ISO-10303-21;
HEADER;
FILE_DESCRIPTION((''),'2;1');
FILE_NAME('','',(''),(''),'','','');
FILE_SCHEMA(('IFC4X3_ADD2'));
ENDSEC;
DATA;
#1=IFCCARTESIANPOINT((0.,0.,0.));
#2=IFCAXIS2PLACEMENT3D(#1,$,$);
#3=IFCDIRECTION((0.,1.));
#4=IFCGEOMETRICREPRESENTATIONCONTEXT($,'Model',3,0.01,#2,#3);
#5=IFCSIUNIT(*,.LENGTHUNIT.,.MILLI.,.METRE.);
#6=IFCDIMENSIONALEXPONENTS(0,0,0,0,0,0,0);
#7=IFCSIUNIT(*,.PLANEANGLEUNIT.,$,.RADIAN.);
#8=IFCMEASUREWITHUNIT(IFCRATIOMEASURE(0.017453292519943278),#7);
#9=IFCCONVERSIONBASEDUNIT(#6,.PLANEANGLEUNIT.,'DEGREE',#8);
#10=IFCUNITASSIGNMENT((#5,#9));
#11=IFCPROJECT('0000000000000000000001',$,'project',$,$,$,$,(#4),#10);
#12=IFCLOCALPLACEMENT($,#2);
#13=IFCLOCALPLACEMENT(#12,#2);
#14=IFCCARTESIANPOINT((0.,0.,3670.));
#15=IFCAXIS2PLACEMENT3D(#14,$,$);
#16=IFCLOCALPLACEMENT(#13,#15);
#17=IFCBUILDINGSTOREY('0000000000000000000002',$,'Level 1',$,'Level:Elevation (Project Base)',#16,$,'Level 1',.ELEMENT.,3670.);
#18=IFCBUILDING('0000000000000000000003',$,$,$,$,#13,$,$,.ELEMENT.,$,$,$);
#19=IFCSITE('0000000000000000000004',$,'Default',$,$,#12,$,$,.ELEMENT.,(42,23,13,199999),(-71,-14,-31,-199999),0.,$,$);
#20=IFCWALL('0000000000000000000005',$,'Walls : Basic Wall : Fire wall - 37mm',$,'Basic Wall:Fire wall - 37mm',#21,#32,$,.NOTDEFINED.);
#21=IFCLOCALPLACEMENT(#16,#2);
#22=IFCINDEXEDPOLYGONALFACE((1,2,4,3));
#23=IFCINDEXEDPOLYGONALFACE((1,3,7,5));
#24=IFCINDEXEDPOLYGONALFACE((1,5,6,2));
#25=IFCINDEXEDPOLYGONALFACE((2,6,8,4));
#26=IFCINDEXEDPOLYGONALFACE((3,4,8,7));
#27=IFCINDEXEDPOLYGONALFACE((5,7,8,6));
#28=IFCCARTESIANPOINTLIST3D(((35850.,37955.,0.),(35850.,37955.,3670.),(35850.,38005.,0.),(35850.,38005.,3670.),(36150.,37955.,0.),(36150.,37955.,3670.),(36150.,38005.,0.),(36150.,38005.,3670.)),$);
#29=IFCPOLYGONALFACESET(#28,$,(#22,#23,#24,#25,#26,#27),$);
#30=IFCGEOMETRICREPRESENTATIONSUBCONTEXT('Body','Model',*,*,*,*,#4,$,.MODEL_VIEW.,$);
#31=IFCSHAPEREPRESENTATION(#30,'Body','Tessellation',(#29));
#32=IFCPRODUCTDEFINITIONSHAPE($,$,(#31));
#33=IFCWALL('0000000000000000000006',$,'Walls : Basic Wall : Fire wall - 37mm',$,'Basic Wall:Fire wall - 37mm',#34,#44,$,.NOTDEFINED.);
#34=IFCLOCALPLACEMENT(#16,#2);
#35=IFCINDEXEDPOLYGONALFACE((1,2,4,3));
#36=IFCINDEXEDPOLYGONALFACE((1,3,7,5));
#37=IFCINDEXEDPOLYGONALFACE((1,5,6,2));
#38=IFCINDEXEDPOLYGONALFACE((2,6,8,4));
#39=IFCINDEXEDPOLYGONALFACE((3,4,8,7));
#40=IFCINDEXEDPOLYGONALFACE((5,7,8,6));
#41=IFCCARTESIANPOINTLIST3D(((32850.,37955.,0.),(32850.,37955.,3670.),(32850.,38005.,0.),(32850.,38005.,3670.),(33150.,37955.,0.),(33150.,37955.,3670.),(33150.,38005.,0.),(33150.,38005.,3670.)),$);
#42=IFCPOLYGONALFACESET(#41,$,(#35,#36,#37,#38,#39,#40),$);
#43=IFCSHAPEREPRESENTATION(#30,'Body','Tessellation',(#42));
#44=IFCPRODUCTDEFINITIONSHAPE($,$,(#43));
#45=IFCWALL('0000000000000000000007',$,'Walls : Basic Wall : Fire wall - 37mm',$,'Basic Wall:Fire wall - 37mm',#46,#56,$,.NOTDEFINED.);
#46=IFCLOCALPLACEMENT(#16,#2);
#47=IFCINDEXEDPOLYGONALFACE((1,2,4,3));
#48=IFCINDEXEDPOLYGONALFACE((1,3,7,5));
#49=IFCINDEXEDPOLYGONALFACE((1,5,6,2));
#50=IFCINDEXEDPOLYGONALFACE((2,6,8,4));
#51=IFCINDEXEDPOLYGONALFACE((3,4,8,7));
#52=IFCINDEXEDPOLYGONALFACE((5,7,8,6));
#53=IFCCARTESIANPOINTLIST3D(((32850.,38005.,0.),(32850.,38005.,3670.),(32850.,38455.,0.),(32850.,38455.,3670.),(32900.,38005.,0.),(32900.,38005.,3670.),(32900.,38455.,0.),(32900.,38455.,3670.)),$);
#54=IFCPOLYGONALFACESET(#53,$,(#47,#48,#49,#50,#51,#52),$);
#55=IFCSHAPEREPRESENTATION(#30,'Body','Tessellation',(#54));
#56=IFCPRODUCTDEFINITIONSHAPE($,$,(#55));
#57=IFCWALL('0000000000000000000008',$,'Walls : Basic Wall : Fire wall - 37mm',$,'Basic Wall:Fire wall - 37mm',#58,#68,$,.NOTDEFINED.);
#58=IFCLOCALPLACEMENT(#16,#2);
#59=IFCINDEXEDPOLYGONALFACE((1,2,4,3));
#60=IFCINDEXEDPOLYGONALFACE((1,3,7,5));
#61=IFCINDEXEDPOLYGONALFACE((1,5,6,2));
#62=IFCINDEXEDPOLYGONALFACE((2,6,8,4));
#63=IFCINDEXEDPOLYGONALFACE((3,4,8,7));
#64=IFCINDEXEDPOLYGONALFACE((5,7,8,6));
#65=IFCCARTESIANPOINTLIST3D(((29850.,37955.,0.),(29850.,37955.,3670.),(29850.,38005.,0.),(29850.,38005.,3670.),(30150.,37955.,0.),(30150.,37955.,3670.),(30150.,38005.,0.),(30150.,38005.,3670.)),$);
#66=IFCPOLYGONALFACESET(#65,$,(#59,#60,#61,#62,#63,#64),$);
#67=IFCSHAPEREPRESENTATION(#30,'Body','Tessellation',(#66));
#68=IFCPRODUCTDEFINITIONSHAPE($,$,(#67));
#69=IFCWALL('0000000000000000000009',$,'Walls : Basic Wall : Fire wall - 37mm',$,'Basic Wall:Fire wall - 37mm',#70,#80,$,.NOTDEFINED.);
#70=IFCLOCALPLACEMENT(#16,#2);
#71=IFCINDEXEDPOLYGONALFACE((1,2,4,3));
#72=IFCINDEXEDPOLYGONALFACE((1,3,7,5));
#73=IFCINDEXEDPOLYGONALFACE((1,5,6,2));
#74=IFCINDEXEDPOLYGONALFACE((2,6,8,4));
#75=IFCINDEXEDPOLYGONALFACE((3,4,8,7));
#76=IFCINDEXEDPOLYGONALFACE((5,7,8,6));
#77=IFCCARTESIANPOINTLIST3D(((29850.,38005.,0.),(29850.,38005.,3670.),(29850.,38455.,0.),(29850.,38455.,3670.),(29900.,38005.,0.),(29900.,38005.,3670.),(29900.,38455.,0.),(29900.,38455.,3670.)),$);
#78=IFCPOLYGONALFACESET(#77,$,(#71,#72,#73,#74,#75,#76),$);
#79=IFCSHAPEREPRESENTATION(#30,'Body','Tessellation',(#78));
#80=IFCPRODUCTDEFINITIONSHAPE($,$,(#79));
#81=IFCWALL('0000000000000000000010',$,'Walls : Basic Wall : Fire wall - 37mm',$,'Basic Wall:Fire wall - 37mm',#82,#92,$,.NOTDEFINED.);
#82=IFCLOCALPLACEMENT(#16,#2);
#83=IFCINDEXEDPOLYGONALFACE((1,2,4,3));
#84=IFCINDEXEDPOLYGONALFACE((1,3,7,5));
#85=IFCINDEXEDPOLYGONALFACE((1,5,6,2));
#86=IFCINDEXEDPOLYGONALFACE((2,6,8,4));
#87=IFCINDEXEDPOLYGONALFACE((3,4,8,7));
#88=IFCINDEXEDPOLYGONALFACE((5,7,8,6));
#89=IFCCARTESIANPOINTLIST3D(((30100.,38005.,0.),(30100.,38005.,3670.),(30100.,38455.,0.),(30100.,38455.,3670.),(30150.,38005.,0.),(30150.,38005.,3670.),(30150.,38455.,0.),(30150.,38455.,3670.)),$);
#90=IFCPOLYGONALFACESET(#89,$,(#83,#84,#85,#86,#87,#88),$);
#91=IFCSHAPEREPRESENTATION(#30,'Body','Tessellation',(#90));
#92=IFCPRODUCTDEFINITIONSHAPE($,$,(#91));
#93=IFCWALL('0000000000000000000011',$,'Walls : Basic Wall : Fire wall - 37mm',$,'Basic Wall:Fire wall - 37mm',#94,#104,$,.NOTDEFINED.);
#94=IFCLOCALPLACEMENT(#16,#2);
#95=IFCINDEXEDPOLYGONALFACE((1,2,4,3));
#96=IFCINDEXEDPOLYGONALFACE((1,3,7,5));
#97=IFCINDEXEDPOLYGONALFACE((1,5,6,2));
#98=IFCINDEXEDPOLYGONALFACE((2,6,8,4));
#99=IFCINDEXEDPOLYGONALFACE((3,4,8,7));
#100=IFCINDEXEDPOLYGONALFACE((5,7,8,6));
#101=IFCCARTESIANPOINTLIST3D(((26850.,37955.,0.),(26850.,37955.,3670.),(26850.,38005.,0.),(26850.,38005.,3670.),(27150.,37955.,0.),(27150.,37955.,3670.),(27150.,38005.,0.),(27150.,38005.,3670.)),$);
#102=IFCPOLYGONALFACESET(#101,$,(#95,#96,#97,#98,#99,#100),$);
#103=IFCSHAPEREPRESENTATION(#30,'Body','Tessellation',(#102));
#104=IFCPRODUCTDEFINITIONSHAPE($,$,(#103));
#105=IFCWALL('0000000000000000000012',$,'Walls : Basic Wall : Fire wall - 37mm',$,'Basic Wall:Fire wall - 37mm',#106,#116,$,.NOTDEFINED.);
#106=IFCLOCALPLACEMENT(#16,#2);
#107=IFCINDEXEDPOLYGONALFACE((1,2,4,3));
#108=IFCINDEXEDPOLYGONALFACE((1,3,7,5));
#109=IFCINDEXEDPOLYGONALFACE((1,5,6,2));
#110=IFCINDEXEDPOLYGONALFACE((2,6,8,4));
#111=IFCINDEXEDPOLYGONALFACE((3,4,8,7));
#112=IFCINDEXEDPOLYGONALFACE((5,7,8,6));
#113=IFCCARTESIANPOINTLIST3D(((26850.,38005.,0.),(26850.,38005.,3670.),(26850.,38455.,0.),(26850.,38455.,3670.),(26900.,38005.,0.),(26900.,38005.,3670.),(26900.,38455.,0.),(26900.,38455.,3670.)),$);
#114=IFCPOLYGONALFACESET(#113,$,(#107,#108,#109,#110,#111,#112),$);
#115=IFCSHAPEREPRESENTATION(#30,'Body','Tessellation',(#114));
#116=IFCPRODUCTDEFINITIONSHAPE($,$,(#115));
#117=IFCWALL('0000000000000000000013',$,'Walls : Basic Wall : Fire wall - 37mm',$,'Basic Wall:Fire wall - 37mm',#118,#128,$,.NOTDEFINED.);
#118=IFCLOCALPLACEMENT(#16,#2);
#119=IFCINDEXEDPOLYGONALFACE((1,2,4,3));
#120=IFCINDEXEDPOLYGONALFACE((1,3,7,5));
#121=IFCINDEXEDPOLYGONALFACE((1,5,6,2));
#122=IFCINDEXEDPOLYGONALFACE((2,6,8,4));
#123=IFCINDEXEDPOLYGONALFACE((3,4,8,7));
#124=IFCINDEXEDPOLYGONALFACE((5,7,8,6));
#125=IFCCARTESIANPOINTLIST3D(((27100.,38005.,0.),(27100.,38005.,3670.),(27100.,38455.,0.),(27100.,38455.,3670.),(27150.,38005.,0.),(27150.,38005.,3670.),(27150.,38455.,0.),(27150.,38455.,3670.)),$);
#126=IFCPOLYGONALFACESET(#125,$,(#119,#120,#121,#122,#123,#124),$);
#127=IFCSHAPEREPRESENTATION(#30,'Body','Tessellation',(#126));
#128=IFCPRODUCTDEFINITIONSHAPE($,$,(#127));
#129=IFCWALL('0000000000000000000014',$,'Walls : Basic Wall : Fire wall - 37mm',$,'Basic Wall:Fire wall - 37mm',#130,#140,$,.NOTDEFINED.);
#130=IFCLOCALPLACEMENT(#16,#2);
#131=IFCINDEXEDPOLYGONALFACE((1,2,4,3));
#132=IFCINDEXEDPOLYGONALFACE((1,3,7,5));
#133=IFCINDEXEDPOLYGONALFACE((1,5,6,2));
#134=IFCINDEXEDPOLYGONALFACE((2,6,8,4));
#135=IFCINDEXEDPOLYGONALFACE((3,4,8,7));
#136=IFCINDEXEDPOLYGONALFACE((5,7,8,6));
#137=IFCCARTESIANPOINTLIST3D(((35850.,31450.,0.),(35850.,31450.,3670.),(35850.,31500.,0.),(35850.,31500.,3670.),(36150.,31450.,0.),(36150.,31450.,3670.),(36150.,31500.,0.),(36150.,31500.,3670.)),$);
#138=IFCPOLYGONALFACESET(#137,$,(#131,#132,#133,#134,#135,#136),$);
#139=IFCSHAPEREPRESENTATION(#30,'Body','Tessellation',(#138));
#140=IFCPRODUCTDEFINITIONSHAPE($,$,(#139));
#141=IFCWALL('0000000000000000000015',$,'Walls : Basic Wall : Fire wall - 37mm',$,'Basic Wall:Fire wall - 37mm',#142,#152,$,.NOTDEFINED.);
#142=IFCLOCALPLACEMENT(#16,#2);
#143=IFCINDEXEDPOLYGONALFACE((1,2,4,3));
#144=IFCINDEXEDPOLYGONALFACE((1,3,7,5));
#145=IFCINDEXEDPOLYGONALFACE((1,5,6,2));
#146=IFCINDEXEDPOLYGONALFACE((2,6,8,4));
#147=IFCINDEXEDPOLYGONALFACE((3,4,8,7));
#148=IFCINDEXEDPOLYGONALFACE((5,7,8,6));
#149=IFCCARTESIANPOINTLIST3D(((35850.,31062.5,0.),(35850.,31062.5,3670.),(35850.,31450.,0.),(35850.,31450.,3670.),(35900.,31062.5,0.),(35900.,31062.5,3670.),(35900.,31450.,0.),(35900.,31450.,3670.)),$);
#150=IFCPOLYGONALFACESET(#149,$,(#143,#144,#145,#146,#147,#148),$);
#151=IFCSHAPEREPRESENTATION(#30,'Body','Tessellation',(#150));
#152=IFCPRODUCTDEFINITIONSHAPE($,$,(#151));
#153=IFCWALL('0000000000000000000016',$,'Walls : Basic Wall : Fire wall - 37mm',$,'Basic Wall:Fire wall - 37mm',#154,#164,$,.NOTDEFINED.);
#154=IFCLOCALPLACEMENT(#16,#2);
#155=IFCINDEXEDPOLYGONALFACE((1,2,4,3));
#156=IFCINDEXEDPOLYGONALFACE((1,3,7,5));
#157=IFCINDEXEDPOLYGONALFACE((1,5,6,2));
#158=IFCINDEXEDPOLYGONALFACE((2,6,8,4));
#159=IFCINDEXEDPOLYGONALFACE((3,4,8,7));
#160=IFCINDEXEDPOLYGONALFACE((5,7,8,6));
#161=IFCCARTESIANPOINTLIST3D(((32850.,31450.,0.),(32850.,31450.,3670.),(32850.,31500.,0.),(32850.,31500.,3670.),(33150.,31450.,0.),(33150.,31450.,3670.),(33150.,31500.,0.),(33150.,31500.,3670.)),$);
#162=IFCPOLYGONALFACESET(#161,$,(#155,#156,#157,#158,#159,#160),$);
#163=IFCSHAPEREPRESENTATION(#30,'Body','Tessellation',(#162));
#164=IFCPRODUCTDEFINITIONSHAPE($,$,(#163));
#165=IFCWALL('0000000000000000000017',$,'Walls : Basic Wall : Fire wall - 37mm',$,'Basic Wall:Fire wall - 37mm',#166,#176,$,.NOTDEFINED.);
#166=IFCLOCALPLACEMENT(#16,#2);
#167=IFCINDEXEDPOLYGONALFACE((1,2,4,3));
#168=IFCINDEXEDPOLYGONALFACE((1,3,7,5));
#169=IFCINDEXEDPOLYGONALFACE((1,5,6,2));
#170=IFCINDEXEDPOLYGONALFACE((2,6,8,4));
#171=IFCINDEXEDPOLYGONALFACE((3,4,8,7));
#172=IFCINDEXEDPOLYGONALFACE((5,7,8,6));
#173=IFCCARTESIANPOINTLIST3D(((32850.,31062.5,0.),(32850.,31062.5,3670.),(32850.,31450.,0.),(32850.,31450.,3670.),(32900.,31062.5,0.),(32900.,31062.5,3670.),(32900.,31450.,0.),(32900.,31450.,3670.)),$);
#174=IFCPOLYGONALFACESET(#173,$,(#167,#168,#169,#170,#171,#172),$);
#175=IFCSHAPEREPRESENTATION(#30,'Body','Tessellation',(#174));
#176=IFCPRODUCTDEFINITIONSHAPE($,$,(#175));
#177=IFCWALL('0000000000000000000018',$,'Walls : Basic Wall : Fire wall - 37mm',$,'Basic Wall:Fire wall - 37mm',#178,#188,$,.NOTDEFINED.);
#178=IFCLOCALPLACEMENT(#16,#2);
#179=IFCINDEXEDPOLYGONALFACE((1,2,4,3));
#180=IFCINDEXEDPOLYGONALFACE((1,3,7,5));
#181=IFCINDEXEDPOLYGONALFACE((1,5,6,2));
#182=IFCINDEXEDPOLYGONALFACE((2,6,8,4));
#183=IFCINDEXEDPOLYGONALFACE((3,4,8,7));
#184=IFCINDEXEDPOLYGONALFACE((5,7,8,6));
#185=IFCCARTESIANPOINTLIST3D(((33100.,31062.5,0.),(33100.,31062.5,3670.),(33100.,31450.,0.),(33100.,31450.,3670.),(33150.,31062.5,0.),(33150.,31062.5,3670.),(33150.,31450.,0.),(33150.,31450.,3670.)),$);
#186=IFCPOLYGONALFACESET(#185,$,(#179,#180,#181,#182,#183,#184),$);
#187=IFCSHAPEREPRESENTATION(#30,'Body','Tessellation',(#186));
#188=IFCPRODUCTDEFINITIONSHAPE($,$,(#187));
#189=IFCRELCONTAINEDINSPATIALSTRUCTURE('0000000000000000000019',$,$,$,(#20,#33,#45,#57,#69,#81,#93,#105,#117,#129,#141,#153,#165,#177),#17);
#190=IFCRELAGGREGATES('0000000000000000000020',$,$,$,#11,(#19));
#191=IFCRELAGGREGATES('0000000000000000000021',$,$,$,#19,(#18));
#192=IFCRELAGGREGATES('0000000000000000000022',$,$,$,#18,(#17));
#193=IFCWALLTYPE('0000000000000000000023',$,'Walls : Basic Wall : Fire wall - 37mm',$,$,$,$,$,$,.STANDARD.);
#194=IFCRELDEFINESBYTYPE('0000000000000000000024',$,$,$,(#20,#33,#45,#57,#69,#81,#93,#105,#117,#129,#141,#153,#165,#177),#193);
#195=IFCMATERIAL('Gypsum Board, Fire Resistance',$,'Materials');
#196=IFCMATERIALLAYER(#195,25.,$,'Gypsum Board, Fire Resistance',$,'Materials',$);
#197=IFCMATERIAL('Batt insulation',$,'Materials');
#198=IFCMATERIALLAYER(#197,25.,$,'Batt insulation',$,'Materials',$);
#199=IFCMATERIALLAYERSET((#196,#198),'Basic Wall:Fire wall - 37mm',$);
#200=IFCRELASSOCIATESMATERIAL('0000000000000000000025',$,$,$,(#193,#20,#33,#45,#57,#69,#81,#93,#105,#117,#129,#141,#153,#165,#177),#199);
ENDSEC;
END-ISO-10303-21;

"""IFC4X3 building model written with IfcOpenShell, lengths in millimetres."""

from ifc_helpers import new_model, entity, si_unit, converted_unit, direction, frame, frame_2d, origin, place, context, subcontext, project, spatial, rectangle, extrude, material, layer, layer_set, type_object, element, save


model = new_model("IFC4X3")

# Units and contexts
model_context = context("Model", 3, precision=0.01, world=origin(), true_north=direction((0.0, 1.0)))
body_context = subcontext(model_context, "Body", "Model", "MODEL_VIEW")
ifc_project = project(units=[si_unit("LENGTHUNIT", "METRE", prefix="MILLI"), converted_unit("PLANEANGLEUNIT", "DEGREE", entity("IfcRatioMeasure", 0.017453292519943278), si_unit("PLANEANGLEUNIT", "RADIAN"), dimensions=[0, 0, 0, 0, 0, 0, 0])], contexts=[model_context])

# Site, building, storey
site_placement = place(None, origin())
site = spatial("IfcSite", under=ifc_project, at=site_placement, Name="Default", CompositionType="ELEMENT", RefLatitude=(42, 23, 13, 199999), RefLongitude=(-71, -14, -31, -199999), RefElevation=0.0)
building_placement = place(site_placement, origin())
building = spatial("IfcBuilding", under=site, at=building_placement, CompositionType="ELEMENT")
storey_placement = place(building_placement, frame((0.0, 0.0, 3670.0)))
storey = spatial("IfcBuildingStorey", under=building, at=storey_placement, Name="Level 1", ObjectType="Level:Elevation (Project Base)", LongName="Level 1", CompositionType="ELEMENT", Elevation=3670.0)

# Walls
ifc_material_1 = material(Name="Gypsum Board, Fire Resistance", Category="Materials")
ifc_layer_1 = layer(ifc_material_1, 25.0, Name="Gypsum Board, Fire Resistance", Category="Materials")
ifc_material_2 = material(Name="Batt insulation", Category="Materials")
ifc_layer_2 = layer(ifc_material_2, 25.0, Name="Batt insulation", Category="Materials")
ifc_layer_set = layer_set([ifc_layer_1, ifc_layer_2], Name="Basic Wall:Fire wall - 37mm")
wall_type = type_object("IfcWallType", Name="Walls : Basic Wall : Fire wall - 37mm", PredefinedType="STANDARD", material=ifc_layer_set)
for number, where, name in (
    (1, (35850.0, 37980.0, 0.0), "Walls : Basic Wall : Fire wall - 37mm"),
    (2, (32850.0, 37980.0, 0.0), "Walls : Basic Wall : Fire wall - 37mm"),
):
    element("IfcWall", number, at=place(storey_placement, frame(where)), inside=storey, type_object=wall_type, material=ifc_layer_set, Name=name, ObjectType="Basic Wall:Fire wall - 37mm", PredefinedType="NOTDEFINED", context=body_context, shape_type="SweptSolid", body=[
        extrude(rectangle(XDim=300.0, YDim=50.0, at=frame_2d((150.0, 0.0), x_axis=(-1.0, 0.0))), origin(), (0.0, 0.0, 1.0), 3670.0),
    ])
wall_1_placement = place(storey_placement, frame((32875.0, 38455.0, 0.0), z_axis=(0.0, 0.0, 1.0), x_axis=(0.0, -1.0, 0.0)))
element("IfcWall", 3, at=wall_1_placement, inside=storey, type_object=wall_type, material=ifc_layer_set, Name="Walls : Basic Wall : Fire wall - 37mm", ObjectType="Basic Wall:Fire wall - 37mm", PredefinedType="NOTDEFINED", context=body_context, shape_type="SweptSolid", body=[
    extrude(rectangle(XDim=450.0, YDim=50.0, at=frame_2d((225.0, 0.0), x_axis=(-1.0, 0.0))), origin(), (0.0, 0.0, 1.0), 3670.0),
])
wall_2_placement = place(storey_placement, frame((29850.0, 37980.0, 0.0)))
element("IfcWall", 4, at=wall_2_placement, inside=storey, type_object=wall_type, material=ifc_layer_set, Name="Walls : Basic Wall : Fire wall - 37mm", ObjectType="Basic Wall:Fire wall - 37mm", PredefinedType="NOTDEFINED", context=body_context, shape_type="SweptSolid", body=[
    extrude(rectangle(XDim=300.0, YDim=50.0, at=frame_2d((150.0, 0.0), x_axis=(-1.0, 0.0))), origin(), (0.0, 0.0, 1.0), 3670.0),
])
for number, where, z_axis, x_axis, name in (
    (5, (29875.0, 38455.0, 0.0), (0.0, 0.0, 1.0), (0.0, -1.0, 0.0), "Walls : Basic Wall : Fire wall - 37mm"),
    (6, (30125.0, 38455.0, 0.0), (0.0, 0.0, 1.0), (0.0, -1.0, 0.0), "Walls : Basic Wall : Fire wall - 37mm"),
):
    element("IfcWall", number, at=place(storey_placement, frame(where, z_axis=z_axis, x_axis=x_axis)), inside=storey, type_object=wall_type, material=ifc_layer_set, Name=name, ObjectType="Basic Wall:Fire wall - 37mm", PredefinedType="NOTDEFINED", context=body_context, shape_type="SweptSolid", body=[
        extrude(rectangle(XDim=450.0, YDim=50.0, at=frame_2d((225.0, 0.0), x_axis=(-1.0, 0.0))), origin(), (0.0, 0.0, 1.0), 3670.0),
    ])
wall_3_placement = place(storey_placement, frame((26850.0, 37980.0, 0.0)))
element("IfcWall", 7, at=wall_3_placement, inside=storey, type_object=wall_type, material=ifc_layer_set, Name="Walls : Basic Wall : Fire wall - 37mm", ObjectType="Basic Wall:Fire wall - 37mm", PredefinedType="NOTDEFINED", context=body_context, shape_type="SweptSolid", body=[
    extrude(rectangle(XDim=300.0, YDim=50.0, at=frame_2d((150.0, 0.0), x_axis=(-1.0, 0.0))), origin(), (0.0, 0.0, 1.0), 3670.0),
])
for number, where, z_axis, x_axis, name in (
    (8, (26875.0, 38455.0, 0.0), (0.0, 0.0, 1.0), (0.0, -1.0, 0.0), "Walls : Basic Wall : Fire wall - 37mm"),
    (9, (27125.0, 38455.0, 0.0), (0.0, 0.0, 1.0), (0.0, -1.0, 0.0), "Walls : Basic Wall : Fire wall - 37mm"),
):
    element("IfcWall", number, at=place(storey_placement, frame(where, z_axis=z_axis, x_axis=x_axis)), inside=storey, type_object=wall_type, material=ifc_layer_set, Name=name, ObjectType="Basic Wall:Fire wall - 37mm", PredefinedType="NOTDEFINED", context=body_context, shape_type="SweptSolid", body=[
        extrude(rectangle(XDim=450.0, YDim=50.0, at=frame_2d((225.0, 0.0), x_axis=(-1.0, 0.0))), origin(), (0.0, 0.0, 1.0), 3670.0),
    ])
wall_4_placement = place(storey_placement, frame((35850.0, 31475.0, 0.0)))
element("IfcWall", 10, at=wall_4_placement, inside=storey, type_object=wall_type, material=ifc_layer_set, Name="Walls : Basic Wall : Fire wall - 37mm", ObjectType="Basic Wall:Fire wall - 37mm", PredefinedType="NOTDEFINED", context=body_context, shape_type="SweptSolid", body=[
    extrude(rectangle(XDim=300.0, YDim=50.0, at=frame_2d((150.0, 0.0), x_axis=(-1.0, 0.0))), origin(), (0.0, 0.0, 1.0), 3670.0),
])
wall_5_placement = place(storey_placement, frame((35875.0, 31450.0, 0.0), z_axis=(0.0, 0.0, 1.0), x_axis=(0.0, -1.0, 0.0)))
element("IfcWall", 11, at=wall_5_placement, inside=storey, type_object=wall_type, material=ifc_layer_set, Name="Walls : Basic Wall : Fire wall - 37mm", ObjectType="Basic Wall:Fire wall - 37mm", PredefinedType="NOTDEFINED", context=body_context, shape_type="SweptSolid", body=[
    extrude(rectangle(XDim=387.5, YDim=50.0, at=frame_2d((193.7, 0.0), x_axis=(-1.0, 0.0))), origin(), (0.0, 0.0, 1.0), 3670.0),
])
wall_6_placement = place(storey_placement, frame((32850.0, 31475.0, 0.0)))
element("IfcWall", 12, at=wall_6_placement, inside=storey, type_object=wall_type, material=ifc_layer_set, Name="Walls : Basic Wall : Fire wall - 37mm", ObjectType="Basic Wall:Fire wall - 37mm", PredefinedType="NOTDEFINED", context=body_context, shape_type="SweptSolid", body=[
    extrude(rectangle(XDim=300.0, YDim=50.0, at=frame_2d((150.0, 0.0), x_axis=(-1.0, 0.0))), origin(), (0.0, 0.0, 1.0), 3670.0),
])
wall_7_placement = place(storey_placement, frame((32875.0, 31450.0, 0.0), z_axis=(0.0, 0.0, 1.0), x_axis=(0.0, -1.0, 0.0)))
element("IfcWall", 13, at=wall_7_placement, inside=storey, type_object=wall_type, material=ifc_layer_set, Name="Walls : Basic Wall : Fire wall - 37mm", ObjectType="Basic Wall:Fire wall - 37mm", PredefinedType="NOTDEFINED", context=body_context, shape_type="SweptSolid", body=[
    extrude(rectangle(XDim=387.5, YDim=50.0, at=frame_2d((193.7, 0.0), x_axis=(-1.0, 0.0))), origin(), (0.0, 0.0, 1.0), 3670.0),
])
wall_8_placement = place(storey_placement, frame((33125.0, 31450.0, 0.0), z_axis=(0.0, 0.0, 1.0), x_axis=(0.0, -1.0, 0.0)))
element("IfcWall", 14, at=wall_8_placement, inside=storey, type_object=wall_type, material=ifc_layer_set, Name="Walls : Basic Wall : Fire wall - 37mm", ObjectType="Basic Wall:Fire wall - 37mm", PredefinedType="NOTDEFINED", context=body_context, shape_type="SweptSolid", body=[
    extrude(rectangle(XDim=387.5, YDim=50.0, at=frame_2d((193.7, 0.0), x_axis=(-1.0, 0.0))), origin(), (0.0, 0.0, 1.0), 3670.0),
])

save(model, "model.ifc")
